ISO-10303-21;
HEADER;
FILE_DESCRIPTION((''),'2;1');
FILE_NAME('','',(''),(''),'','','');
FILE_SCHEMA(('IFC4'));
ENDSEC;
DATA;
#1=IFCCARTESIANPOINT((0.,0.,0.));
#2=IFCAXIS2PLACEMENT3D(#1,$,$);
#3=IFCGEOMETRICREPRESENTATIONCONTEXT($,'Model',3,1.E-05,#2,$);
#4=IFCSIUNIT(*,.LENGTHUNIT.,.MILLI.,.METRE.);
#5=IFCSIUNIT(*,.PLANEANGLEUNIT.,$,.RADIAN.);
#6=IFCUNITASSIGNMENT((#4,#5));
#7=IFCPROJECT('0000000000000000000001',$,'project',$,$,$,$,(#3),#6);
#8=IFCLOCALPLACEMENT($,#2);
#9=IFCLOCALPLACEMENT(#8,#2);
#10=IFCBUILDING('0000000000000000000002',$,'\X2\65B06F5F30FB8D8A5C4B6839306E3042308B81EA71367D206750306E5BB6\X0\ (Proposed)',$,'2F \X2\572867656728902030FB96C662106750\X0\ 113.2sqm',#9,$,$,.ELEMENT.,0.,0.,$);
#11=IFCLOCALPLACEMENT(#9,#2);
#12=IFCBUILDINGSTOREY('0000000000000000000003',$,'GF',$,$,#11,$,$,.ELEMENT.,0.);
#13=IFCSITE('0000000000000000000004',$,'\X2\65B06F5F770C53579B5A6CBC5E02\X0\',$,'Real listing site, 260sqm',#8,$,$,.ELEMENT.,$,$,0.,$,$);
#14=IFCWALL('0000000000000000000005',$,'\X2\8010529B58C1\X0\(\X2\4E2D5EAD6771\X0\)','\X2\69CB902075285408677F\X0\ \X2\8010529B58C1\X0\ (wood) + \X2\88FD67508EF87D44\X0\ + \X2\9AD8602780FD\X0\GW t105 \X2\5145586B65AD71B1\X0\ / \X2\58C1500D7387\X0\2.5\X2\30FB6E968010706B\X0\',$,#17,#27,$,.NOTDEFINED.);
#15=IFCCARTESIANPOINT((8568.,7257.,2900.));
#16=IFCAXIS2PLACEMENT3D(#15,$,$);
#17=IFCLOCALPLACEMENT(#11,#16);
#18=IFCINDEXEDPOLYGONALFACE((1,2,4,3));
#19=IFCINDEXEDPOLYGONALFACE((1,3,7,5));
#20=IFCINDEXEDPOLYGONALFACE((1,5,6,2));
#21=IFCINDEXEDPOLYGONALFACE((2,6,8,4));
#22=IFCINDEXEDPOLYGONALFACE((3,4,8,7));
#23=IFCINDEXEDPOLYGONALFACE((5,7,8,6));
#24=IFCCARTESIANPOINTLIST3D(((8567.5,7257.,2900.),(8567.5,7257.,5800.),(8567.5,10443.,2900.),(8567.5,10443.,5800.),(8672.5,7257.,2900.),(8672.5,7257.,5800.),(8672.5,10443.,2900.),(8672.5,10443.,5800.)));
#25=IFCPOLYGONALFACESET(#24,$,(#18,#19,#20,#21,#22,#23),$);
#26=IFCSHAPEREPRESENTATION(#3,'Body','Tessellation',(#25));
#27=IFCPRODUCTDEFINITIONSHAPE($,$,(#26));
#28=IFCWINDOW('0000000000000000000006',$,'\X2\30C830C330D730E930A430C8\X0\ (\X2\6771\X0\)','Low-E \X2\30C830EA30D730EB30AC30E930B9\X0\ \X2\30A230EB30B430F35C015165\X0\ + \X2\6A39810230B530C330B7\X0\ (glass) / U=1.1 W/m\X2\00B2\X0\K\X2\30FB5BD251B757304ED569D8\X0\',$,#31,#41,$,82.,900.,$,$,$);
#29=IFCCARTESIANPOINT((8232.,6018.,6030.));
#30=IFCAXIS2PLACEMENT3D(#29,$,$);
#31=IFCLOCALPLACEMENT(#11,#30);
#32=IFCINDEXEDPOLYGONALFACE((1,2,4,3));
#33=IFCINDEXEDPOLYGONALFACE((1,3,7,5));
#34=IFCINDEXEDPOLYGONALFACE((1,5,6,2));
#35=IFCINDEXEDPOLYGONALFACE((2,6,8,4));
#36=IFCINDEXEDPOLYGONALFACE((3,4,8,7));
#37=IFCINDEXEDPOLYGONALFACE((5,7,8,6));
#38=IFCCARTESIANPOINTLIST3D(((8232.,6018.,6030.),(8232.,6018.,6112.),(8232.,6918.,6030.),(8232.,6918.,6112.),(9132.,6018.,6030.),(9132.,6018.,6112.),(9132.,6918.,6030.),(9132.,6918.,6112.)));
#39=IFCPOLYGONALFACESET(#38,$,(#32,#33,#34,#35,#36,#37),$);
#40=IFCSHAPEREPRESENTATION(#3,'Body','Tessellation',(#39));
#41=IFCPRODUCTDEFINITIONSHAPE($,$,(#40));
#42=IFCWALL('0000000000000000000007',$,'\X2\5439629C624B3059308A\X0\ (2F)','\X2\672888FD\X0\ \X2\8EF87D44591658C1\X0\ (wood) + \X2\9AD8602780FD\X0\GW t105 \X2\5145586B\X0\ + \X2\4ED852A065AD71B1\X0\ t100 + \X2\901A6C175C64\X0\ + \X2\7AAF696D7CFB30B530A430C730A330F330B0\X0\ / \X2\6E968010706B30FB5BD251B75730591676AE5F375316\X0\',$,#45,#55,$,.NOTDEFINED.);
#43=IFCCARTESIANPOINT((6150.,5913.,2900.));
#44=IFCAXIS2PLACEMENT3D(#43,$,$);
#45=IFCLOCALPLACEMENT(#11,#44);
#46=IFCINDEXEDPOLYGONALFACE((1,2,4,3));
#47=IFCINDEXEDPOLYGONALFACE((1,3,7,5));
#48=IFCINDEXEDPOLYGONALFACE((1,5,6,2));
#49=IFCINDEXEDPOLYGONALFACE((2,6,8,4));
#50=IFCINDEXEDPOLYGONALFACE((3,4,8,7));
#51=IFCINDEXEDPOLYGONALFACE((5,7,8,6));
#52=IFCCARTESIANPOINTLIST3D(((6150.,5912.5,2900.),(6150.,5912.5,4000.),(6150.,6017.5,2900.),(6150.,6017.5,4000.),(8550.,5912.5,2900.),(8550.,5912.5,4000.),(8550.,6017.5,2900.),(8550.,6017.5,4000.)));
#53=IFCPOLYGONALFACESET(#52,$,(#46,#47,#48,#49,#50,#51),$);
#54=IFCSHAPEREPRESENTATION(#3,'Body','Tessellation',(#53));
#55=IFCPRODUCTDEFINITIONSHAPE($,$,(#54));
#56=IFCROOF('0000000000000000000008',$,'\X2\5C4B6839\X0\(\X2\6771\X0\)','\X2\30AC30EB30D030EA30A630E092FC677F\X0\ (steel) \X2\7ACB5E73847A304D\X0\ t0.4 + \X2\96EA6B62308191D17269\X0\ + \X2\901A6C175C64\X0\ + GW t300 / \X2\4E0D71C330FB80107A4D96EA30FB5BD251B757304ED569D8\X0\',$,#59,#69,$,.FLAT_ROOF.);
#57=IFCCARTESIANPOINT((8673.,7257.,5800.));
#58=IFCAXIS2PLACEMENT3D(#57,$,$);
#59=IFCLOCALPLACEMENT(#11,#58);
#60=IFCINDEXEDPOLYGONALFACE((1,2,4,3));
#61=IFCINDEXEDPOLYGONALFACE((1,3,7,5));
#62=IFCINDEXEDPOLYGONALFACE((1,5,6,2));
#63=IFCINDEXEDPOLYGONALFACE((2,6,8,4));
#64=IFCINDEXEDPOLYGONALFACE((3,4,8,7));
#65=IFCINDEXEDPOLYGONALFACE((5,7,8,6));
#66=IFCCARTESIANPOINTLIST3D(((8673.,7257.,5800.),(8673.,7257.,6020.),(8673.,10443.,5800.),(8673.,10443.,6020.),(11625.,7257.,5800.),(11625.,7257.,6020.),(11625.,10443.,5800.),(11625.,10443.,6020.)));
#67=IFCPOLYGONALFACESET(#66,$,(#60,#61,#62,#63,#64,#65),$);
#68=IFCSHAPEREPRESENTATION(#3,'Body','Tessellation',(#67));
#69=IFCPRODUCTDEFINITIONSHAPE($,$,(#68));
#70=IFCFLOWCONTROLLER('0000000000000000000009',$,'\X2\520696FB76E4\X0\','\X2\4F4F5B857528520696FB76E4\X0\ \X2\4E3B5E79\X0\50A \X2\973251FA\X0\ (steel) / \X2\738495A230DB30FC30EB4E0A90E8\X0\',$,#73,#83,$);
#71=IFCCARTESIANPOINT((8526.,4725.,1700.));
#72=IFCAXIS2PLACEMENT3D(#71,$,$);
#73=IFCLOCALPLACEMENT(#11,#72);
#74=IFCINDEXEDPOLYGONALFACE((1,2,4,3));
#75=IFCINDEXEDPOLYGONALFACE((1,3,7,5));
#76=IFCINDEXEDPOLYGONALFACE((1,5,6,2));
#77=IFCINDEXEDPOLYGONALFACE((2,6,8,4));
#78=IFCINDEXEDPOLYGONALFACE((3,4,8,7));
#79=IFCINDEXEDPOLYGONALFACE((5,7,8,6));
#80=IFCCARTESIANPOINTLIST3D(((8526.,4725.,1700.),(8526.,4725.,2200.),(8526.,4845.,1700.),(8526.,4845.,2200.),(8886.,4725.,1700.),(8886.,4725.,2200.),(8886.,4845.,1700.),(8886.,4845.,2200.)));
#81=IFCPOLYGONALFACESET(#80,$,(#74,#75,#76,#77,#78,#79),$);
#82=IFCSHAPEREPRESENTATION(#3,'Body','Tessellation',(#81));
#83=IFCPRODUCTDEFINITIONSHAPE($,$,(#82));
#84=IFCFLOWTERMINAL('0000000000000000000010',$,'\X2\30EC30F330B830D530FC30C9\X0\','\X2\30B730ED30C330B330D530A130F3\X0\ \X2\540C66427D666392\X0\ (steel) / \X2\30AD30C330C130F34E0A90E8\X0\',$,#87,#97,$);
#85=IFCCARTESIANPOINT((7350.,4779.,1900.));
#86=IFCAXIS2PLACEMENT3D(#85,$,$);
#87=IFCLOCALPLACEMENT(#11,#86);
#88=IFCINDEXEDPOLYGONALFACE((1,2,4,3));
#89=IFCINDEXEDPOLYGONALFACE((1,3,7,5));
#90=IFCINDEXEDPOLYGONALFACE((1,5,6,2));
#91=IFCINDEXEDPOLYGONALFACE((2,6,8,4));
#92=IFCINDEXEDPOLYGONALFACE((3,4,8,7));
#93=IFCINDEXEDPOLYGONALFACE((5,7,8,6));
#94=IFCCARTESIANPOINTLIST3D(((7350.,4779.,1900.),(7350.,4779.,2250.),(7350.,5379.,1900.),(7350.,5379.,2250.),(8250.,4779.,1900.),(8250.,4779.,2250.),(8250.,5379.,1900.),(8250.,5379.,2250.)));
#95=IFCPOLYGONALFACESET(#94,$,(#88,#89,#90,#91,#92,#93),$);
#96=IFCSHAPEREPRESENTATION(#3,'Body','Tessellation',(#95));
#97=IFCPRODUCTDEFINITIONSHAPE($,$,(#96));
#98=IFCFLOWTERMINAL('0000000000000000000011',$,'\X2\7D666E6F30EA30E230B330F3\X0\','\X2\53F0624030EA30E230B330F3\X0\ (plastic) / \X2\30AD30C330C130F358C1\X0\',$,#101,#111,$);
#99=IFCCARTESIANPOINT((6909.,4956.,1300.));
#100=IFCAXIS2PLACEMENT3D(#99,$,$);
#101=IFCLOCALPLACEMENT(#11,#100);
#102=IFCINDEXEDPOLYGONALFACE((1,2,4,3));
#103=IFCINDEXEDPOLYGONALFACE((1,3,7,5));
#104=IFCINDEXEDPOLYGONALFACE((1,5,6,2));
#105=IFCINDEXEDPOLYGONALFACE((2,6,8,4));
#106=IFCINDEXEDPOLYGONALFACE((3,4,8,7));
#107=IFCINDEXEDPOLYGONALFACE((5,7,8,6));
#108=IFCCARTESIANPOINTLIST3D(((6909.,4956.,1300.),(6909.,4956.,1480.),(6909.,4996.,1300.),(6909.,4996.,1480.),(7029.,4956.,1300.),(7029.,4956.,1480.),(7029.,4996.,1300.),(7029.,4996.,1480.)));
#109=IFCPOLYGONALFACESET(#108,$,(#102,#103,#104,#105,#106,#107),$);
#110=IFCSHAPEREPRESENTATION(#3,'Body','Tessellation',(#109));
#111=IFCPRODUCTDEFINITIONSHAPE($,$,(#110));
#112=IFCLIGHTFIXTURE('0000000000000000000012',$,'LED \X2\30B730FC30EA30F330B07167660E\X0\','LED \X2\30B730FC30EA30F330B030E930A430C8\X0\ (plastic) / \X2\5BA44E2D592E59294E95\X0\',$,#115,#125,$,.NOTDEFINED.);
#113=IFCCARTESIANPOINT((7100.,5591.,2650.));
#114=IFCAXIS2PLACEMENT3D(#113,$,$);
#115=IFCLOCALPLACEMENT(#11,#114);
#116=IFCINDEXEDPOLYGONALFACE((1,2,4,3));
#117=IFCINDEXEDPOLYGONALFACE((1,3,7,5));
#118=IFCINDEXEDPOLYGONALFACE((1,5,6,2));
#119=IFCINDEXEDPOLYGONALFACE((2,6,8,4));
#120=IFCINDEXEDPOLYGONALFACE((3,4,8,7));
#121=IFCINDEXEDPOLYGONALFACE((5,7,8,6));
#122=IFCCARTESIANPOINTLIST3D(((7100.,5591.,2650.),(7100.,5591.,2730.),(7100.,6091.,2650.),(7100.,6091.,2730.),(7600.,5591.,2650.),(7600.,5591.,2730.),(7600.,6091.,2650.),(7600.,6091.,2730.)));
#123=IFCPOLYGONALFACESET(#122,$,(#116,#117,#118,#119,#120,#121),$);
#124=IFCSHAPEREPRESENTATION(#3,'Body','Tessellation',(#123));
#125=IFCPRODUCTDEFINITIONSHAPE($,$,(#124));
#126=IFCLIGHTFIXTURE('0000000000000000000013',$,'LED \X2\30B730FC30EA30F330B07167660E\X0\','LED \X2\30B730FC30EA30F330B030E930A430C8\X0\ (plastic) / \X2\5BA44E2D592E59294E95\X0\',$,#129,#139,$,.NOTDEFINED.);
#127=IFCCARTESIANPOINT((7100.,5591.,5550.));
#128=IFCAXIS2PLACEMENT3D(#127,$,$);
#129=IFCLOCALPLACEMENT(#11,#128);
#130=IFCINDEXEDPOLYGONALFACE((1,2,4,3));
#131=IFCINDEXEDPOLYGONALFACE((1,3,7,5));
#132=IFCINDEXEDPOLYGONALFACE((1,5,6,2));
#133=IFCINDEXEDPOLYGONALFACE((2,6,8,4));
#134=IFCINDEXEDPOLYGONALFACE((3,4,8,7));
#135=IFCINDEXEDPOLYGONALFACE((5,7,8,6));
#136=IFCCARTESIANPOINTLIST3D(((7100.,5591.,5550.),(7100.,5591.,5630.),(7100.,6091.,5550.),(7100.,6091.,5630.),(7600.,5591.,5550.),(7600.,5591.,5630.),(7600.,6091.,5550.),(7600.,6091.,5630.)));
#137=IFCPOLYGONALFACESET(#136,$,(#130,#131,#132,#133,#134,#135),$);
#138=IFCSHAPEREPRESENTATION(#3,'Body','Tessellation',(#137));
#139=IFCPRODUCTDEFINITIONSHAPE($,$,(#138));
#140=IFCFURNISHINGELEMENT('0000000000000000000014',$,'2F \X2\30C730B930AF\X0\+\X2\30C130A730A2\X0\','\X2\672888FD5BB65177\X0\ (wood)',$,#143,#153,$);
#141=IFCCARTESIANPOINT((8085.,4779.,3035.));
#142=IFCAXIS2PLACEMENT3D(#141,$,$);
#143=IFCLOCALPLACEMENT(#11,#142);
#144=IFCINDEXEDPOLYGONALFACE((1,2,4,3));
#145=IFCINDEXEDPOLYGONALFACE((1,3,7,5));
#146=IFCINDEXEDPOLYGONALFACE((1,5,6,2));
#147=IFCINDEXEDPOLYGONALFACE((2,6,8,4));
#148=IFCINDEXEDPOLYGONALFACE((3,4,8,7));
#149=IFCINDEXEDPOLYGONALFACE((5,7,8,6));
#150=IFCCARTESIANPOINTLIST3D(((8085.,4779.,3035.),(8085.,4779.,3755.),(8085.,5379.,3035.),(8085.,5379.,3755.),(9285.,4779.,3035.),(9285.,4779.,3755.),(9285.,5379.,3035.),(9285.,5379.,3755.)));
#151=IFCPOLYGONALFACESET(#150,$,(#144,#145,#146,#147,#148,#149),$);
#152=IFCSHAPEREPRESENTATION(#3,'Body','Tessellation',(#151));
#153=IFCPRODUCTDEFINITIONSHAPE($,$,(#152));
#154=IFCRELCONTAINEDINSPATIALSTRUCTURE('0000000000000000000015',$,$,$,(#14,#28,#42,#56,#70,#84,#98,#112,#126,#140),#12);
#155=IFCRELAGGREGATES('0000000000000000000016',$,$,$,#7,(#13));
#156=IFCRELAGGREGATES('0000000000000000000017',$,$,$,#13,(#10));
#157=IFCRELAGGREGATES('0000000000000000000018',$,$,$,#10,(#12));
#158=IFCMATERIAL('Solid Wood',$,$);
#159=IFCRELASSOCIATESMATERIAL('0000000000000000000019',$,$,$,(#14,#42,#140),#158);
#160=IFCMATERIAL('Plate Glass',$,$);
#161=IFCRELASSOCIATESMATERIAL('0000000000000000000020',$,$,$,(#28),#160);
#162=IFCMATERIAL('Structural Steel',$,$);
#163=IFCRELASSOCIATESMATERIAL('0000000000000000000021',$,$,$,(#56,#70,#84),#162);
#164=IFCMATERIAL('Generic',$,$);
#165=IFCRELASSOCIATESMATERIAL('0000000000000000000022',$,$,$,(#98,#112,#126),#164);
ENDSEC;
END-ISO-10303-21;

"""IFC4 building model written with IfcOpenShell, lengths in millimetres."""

from ifc_helpers import new_model, si_unit, frame, frame_2d, origin, place, context, project, spatial, rectangle, extrude, material, element, save


model = new_model("IFC4")

# Units and contexts
model_context = context("Model", 3, precision=1e-05, world=origin())
ifc_project = project(units=[si_unit("LENGTHUNIT", "METRE", prefix="MILLI"), si_unit("PLANEANGLEUNIT", "RADIAN")], contexts=[model_context])

# Site, building, storey
site_placement = place(None, origin())
site = spatial("IfcSite", under=ifc_project, at=site_placement, Name="新潟県南魚沼市", ObjectType="Real listing site, 260sqm", CompositionType="ELEMENT", RefElevation=0.0)
building_placement = place(site_placement, origin())
building = spatial("IfcBuilding", under=site, at=building_placement, Name="新潟・越屋根のある自然素材の家 (Proposed)", ObjectType="2F 在来木造・集成材 113.2sqm", CompositionType="ELEMENT", ElevationOfRefHeight=0.0, ElevationOfTerrain=0.0)
storey_placement = place(building_placement, origin())
storey = spatial("IfcBuildingStorey", under=building, at=storey_placement, Name="GF", CompositionType="ELEMENT", Elevation=0.0)

# Shared definitions
ifc_material_1 = material(Name="Solid Wood")

# Shared definitions
ifc_material_2 = material(Name="Plate Glass")

# Wall
wall_1_placement = place(storey_placement, frame((8568.0, 7257.0, 2900.0)))
element("IfcWall", 1, at=wall_1_placement, inside=storey, material=ifc_material_1, Name="耐力壁(中庭東)", Description="構造用合板 耐力壁 (wood) + 製材軸組 + 高性能GW t105 充填断熱 / 壁倍率2.5・準耐火", PredefinedType="NOTDEFINED", context=model_context, shape_type="SweptSolid", body=[
    extrude(rectangle(XDim=105.0, YDim=3186.0, at=frame_2d((52.0, 1593.0))), frame((8568.0, 7257.0, 2900.0)), (0.0, 0.0, 1.0), 2900.0),
])

# Window
window_1_placement = place(storey_placement, frame((8232.0, 6018.0, 6030.0)))
element("IfcWindow", 2, at=window_1_placement, inside=storey, material=ifc_material_2, Name="トップライト (東)", Description="Low-E トリプルガラス アルゴン封入 + 樹脂サッシ (glass) / U=1.1 W/m²K・寒冷地仕様", OverallHeight=82.0, OverallWidth=900.0, context=model_context, shape_type="SweptSolid", body=[
    extrude(rectangle(XDim=900.0, YDim=900.0, at=frame_2d((450.0, 450.0))), frame((8232.0, 6018.0, 6030.0)), (0.0, 0.0, 1.0), 82.0),
])

# Wall
wall_2_placement = place(storey_placement, frame((6150.0, 5913.0, 2900.0)))
element("IfcWall", 3, at=wall_2_placement, inside=storey, material=ifc_material_1, Name="吹抜手すり (2F)", Description="木製 軸組外壁 (wood) + 高性能GW t105 充填 + 付加断熱 t100 + 通気層 + 窯業系サイディング / 準耐火・寒冷地外皮強化", PredefinedType="NOTDEFINED", context=model_context, shape_type="SweptSolid", body=[
    extrude(rectangle(XDim=2400.0, YDim=105.0, at=frame_2d((1200.0, 52.0))), frame((6150.0, 5913.0, 2900.0)), (0.0, 0.0, 1.0), 1100.0),
])

# Roof
ifc_material_3 = material(Name="Structural Steel")
for number, where, name in (
    (4, (8673.0, 7257.0, 5800.0), "屋根(東)"),
):
    element("IfcRoof", number, at=place(storey_placement, frame(where)), inside=storey, material=ifc_material_3, Name=name, Description="ガルバリウム鋼板 (steel) 立平葺き t0.4 + 雪止め金物 + 通気層 + GW t300 / 不燃・耐積雪・寒冷地仕様", PredefinedType="FLAT_ROOF", context=model_context, shape_type="SweptSolid", body=[
        extrude(rectangle(XDim=2952.0, YDim=3186.0, at=frame_2d((1476.0, 1593.0))), frame((8673.0, 7257.0, 5800.0)), (0.0, 0.0, 1.0), 220.0),
    ])

# Flow controller
flow_controller_placement = place(storey_placement, frame((8526.0, 4725.0, 1700.0)))
element("IfcFlowController", 5, at=flow_controller_placement, inside=storey, material=ifc_material_3, Name="分電盤", Description="住宅用分電盤 主幹50A 露出 (steel) / 玄関ホール上部", context=model_context, shape_type="SweptSolid", body=[
    extrude(rectangle(XDim=360.0, YDim=120.0, at=frame_2d((180.0, 60.0))), frame((8526.0, 4725.0, 1700.0)), (0.0, 0.0, 1.0), 500.0),
])

# Flow terminals
flow_terminal_1_placement = place(storey_placement, frame((7350.0, 4779.0, 1900.0)))
element("IfcFlowTerminal", 6, at=flow_terminal_1_placement, inside=storey, material=ifc_material_3, Name="レンジフード", Description="シロッコファン 同時給排 (steel) / キッチン上部", context=model_context, shape_type="SweptSolid", body=[
    extrude(rectangle(XDim=900.0, YDim=600.0, at=frame_2d((450.0, 300.0))), frame((7350.0, 4779.0, 1900.0)), (0.0, 0.0, 1.0), 350.0),
])
ifc_material_4 = material(Name="Generic")
flow_terminal_2_placement = place(storey_placement, frame((6909.0, 4956.0, 1300.0)))
element("IfcFlowTerminal", 7, at=flow_terminal_2_placement, inside=storey, material=ifc_material_4, Name="給湯リモコン", Description="台所リモコン (plastic) / キッチン壁", context=model_context, shape_type="SweptSolid", body=[
    extrude(rectangle(XDim=120.0, YDim=40.0, at=frame_2d((60.0, 20.0))), frame((6909.0, 4956.0, 1300.0)), (0.0, 0.0, 1.0), 180.0),
])

# Light fixtures
light_fixture_1_placement = place(storey_placement, frame((7100.0, 5591.0, 2650.0)))
element("IfcLightFixture", 8, at=light_fixture_1_placement, inside=storey, material=ifc_material_4, Name="LED シーリング照明", Description="LED シーリングライト (plastic) / 室中央天井", PredefinedType="NOTDEFINED", context=model_context, shape_type="SweptSolid", body=[
    extrude(rectangle(XDim=500.0, YDim=500.0, at=frame_2d((250.0, 250.0))), frame((7100.0, 5591.0, 2650.0)), (0.0, 0.0, 1.0), 80.0),
])
light_fixture_2_placement = place(storey_placement, frame((7100.0, 5591.0, 5550.0)))
element("IfcLightFixture", 9, at=light_fixture_2_placement, inside=storey, material=ifc_material_4, Name="LED シーリング照明", Description="LED シーリングライト (plastic) / 室中央天井", PredefinedType="NOTDEFINED", context=model_context, shape_type="SweptSolid", body=[
    extrude(rectangle(XDim=500.0, YDim=500.0, at=frame_2d((250.0, 250.0))), frame((7100.0, 5591.0, 5550.0)), (0.0, 0.0, 1.0), 80.0),
])

# Furnishing element
furnishing_placement = place(storey_placement, frame((8085.0, 4779.0, 3035.0)))
element("IfcFurnishingElement", 10, at=furnishing_placement, inside=storey, material=ifc_material_1, Name="2F デスク+チェア", Description="木製家具 (wood)", context=model_context, shape_type="SweptSolid", body=[
    extrude(rectangle(XDim=1200.0, YDim=600.0, at=frame_2d((600.0, 300.0))), frame((8085.0, 4779.0, 3035.0)), (0.0, 0.0, 1.0), 720.0),
])

save(model, "model.ifc")
